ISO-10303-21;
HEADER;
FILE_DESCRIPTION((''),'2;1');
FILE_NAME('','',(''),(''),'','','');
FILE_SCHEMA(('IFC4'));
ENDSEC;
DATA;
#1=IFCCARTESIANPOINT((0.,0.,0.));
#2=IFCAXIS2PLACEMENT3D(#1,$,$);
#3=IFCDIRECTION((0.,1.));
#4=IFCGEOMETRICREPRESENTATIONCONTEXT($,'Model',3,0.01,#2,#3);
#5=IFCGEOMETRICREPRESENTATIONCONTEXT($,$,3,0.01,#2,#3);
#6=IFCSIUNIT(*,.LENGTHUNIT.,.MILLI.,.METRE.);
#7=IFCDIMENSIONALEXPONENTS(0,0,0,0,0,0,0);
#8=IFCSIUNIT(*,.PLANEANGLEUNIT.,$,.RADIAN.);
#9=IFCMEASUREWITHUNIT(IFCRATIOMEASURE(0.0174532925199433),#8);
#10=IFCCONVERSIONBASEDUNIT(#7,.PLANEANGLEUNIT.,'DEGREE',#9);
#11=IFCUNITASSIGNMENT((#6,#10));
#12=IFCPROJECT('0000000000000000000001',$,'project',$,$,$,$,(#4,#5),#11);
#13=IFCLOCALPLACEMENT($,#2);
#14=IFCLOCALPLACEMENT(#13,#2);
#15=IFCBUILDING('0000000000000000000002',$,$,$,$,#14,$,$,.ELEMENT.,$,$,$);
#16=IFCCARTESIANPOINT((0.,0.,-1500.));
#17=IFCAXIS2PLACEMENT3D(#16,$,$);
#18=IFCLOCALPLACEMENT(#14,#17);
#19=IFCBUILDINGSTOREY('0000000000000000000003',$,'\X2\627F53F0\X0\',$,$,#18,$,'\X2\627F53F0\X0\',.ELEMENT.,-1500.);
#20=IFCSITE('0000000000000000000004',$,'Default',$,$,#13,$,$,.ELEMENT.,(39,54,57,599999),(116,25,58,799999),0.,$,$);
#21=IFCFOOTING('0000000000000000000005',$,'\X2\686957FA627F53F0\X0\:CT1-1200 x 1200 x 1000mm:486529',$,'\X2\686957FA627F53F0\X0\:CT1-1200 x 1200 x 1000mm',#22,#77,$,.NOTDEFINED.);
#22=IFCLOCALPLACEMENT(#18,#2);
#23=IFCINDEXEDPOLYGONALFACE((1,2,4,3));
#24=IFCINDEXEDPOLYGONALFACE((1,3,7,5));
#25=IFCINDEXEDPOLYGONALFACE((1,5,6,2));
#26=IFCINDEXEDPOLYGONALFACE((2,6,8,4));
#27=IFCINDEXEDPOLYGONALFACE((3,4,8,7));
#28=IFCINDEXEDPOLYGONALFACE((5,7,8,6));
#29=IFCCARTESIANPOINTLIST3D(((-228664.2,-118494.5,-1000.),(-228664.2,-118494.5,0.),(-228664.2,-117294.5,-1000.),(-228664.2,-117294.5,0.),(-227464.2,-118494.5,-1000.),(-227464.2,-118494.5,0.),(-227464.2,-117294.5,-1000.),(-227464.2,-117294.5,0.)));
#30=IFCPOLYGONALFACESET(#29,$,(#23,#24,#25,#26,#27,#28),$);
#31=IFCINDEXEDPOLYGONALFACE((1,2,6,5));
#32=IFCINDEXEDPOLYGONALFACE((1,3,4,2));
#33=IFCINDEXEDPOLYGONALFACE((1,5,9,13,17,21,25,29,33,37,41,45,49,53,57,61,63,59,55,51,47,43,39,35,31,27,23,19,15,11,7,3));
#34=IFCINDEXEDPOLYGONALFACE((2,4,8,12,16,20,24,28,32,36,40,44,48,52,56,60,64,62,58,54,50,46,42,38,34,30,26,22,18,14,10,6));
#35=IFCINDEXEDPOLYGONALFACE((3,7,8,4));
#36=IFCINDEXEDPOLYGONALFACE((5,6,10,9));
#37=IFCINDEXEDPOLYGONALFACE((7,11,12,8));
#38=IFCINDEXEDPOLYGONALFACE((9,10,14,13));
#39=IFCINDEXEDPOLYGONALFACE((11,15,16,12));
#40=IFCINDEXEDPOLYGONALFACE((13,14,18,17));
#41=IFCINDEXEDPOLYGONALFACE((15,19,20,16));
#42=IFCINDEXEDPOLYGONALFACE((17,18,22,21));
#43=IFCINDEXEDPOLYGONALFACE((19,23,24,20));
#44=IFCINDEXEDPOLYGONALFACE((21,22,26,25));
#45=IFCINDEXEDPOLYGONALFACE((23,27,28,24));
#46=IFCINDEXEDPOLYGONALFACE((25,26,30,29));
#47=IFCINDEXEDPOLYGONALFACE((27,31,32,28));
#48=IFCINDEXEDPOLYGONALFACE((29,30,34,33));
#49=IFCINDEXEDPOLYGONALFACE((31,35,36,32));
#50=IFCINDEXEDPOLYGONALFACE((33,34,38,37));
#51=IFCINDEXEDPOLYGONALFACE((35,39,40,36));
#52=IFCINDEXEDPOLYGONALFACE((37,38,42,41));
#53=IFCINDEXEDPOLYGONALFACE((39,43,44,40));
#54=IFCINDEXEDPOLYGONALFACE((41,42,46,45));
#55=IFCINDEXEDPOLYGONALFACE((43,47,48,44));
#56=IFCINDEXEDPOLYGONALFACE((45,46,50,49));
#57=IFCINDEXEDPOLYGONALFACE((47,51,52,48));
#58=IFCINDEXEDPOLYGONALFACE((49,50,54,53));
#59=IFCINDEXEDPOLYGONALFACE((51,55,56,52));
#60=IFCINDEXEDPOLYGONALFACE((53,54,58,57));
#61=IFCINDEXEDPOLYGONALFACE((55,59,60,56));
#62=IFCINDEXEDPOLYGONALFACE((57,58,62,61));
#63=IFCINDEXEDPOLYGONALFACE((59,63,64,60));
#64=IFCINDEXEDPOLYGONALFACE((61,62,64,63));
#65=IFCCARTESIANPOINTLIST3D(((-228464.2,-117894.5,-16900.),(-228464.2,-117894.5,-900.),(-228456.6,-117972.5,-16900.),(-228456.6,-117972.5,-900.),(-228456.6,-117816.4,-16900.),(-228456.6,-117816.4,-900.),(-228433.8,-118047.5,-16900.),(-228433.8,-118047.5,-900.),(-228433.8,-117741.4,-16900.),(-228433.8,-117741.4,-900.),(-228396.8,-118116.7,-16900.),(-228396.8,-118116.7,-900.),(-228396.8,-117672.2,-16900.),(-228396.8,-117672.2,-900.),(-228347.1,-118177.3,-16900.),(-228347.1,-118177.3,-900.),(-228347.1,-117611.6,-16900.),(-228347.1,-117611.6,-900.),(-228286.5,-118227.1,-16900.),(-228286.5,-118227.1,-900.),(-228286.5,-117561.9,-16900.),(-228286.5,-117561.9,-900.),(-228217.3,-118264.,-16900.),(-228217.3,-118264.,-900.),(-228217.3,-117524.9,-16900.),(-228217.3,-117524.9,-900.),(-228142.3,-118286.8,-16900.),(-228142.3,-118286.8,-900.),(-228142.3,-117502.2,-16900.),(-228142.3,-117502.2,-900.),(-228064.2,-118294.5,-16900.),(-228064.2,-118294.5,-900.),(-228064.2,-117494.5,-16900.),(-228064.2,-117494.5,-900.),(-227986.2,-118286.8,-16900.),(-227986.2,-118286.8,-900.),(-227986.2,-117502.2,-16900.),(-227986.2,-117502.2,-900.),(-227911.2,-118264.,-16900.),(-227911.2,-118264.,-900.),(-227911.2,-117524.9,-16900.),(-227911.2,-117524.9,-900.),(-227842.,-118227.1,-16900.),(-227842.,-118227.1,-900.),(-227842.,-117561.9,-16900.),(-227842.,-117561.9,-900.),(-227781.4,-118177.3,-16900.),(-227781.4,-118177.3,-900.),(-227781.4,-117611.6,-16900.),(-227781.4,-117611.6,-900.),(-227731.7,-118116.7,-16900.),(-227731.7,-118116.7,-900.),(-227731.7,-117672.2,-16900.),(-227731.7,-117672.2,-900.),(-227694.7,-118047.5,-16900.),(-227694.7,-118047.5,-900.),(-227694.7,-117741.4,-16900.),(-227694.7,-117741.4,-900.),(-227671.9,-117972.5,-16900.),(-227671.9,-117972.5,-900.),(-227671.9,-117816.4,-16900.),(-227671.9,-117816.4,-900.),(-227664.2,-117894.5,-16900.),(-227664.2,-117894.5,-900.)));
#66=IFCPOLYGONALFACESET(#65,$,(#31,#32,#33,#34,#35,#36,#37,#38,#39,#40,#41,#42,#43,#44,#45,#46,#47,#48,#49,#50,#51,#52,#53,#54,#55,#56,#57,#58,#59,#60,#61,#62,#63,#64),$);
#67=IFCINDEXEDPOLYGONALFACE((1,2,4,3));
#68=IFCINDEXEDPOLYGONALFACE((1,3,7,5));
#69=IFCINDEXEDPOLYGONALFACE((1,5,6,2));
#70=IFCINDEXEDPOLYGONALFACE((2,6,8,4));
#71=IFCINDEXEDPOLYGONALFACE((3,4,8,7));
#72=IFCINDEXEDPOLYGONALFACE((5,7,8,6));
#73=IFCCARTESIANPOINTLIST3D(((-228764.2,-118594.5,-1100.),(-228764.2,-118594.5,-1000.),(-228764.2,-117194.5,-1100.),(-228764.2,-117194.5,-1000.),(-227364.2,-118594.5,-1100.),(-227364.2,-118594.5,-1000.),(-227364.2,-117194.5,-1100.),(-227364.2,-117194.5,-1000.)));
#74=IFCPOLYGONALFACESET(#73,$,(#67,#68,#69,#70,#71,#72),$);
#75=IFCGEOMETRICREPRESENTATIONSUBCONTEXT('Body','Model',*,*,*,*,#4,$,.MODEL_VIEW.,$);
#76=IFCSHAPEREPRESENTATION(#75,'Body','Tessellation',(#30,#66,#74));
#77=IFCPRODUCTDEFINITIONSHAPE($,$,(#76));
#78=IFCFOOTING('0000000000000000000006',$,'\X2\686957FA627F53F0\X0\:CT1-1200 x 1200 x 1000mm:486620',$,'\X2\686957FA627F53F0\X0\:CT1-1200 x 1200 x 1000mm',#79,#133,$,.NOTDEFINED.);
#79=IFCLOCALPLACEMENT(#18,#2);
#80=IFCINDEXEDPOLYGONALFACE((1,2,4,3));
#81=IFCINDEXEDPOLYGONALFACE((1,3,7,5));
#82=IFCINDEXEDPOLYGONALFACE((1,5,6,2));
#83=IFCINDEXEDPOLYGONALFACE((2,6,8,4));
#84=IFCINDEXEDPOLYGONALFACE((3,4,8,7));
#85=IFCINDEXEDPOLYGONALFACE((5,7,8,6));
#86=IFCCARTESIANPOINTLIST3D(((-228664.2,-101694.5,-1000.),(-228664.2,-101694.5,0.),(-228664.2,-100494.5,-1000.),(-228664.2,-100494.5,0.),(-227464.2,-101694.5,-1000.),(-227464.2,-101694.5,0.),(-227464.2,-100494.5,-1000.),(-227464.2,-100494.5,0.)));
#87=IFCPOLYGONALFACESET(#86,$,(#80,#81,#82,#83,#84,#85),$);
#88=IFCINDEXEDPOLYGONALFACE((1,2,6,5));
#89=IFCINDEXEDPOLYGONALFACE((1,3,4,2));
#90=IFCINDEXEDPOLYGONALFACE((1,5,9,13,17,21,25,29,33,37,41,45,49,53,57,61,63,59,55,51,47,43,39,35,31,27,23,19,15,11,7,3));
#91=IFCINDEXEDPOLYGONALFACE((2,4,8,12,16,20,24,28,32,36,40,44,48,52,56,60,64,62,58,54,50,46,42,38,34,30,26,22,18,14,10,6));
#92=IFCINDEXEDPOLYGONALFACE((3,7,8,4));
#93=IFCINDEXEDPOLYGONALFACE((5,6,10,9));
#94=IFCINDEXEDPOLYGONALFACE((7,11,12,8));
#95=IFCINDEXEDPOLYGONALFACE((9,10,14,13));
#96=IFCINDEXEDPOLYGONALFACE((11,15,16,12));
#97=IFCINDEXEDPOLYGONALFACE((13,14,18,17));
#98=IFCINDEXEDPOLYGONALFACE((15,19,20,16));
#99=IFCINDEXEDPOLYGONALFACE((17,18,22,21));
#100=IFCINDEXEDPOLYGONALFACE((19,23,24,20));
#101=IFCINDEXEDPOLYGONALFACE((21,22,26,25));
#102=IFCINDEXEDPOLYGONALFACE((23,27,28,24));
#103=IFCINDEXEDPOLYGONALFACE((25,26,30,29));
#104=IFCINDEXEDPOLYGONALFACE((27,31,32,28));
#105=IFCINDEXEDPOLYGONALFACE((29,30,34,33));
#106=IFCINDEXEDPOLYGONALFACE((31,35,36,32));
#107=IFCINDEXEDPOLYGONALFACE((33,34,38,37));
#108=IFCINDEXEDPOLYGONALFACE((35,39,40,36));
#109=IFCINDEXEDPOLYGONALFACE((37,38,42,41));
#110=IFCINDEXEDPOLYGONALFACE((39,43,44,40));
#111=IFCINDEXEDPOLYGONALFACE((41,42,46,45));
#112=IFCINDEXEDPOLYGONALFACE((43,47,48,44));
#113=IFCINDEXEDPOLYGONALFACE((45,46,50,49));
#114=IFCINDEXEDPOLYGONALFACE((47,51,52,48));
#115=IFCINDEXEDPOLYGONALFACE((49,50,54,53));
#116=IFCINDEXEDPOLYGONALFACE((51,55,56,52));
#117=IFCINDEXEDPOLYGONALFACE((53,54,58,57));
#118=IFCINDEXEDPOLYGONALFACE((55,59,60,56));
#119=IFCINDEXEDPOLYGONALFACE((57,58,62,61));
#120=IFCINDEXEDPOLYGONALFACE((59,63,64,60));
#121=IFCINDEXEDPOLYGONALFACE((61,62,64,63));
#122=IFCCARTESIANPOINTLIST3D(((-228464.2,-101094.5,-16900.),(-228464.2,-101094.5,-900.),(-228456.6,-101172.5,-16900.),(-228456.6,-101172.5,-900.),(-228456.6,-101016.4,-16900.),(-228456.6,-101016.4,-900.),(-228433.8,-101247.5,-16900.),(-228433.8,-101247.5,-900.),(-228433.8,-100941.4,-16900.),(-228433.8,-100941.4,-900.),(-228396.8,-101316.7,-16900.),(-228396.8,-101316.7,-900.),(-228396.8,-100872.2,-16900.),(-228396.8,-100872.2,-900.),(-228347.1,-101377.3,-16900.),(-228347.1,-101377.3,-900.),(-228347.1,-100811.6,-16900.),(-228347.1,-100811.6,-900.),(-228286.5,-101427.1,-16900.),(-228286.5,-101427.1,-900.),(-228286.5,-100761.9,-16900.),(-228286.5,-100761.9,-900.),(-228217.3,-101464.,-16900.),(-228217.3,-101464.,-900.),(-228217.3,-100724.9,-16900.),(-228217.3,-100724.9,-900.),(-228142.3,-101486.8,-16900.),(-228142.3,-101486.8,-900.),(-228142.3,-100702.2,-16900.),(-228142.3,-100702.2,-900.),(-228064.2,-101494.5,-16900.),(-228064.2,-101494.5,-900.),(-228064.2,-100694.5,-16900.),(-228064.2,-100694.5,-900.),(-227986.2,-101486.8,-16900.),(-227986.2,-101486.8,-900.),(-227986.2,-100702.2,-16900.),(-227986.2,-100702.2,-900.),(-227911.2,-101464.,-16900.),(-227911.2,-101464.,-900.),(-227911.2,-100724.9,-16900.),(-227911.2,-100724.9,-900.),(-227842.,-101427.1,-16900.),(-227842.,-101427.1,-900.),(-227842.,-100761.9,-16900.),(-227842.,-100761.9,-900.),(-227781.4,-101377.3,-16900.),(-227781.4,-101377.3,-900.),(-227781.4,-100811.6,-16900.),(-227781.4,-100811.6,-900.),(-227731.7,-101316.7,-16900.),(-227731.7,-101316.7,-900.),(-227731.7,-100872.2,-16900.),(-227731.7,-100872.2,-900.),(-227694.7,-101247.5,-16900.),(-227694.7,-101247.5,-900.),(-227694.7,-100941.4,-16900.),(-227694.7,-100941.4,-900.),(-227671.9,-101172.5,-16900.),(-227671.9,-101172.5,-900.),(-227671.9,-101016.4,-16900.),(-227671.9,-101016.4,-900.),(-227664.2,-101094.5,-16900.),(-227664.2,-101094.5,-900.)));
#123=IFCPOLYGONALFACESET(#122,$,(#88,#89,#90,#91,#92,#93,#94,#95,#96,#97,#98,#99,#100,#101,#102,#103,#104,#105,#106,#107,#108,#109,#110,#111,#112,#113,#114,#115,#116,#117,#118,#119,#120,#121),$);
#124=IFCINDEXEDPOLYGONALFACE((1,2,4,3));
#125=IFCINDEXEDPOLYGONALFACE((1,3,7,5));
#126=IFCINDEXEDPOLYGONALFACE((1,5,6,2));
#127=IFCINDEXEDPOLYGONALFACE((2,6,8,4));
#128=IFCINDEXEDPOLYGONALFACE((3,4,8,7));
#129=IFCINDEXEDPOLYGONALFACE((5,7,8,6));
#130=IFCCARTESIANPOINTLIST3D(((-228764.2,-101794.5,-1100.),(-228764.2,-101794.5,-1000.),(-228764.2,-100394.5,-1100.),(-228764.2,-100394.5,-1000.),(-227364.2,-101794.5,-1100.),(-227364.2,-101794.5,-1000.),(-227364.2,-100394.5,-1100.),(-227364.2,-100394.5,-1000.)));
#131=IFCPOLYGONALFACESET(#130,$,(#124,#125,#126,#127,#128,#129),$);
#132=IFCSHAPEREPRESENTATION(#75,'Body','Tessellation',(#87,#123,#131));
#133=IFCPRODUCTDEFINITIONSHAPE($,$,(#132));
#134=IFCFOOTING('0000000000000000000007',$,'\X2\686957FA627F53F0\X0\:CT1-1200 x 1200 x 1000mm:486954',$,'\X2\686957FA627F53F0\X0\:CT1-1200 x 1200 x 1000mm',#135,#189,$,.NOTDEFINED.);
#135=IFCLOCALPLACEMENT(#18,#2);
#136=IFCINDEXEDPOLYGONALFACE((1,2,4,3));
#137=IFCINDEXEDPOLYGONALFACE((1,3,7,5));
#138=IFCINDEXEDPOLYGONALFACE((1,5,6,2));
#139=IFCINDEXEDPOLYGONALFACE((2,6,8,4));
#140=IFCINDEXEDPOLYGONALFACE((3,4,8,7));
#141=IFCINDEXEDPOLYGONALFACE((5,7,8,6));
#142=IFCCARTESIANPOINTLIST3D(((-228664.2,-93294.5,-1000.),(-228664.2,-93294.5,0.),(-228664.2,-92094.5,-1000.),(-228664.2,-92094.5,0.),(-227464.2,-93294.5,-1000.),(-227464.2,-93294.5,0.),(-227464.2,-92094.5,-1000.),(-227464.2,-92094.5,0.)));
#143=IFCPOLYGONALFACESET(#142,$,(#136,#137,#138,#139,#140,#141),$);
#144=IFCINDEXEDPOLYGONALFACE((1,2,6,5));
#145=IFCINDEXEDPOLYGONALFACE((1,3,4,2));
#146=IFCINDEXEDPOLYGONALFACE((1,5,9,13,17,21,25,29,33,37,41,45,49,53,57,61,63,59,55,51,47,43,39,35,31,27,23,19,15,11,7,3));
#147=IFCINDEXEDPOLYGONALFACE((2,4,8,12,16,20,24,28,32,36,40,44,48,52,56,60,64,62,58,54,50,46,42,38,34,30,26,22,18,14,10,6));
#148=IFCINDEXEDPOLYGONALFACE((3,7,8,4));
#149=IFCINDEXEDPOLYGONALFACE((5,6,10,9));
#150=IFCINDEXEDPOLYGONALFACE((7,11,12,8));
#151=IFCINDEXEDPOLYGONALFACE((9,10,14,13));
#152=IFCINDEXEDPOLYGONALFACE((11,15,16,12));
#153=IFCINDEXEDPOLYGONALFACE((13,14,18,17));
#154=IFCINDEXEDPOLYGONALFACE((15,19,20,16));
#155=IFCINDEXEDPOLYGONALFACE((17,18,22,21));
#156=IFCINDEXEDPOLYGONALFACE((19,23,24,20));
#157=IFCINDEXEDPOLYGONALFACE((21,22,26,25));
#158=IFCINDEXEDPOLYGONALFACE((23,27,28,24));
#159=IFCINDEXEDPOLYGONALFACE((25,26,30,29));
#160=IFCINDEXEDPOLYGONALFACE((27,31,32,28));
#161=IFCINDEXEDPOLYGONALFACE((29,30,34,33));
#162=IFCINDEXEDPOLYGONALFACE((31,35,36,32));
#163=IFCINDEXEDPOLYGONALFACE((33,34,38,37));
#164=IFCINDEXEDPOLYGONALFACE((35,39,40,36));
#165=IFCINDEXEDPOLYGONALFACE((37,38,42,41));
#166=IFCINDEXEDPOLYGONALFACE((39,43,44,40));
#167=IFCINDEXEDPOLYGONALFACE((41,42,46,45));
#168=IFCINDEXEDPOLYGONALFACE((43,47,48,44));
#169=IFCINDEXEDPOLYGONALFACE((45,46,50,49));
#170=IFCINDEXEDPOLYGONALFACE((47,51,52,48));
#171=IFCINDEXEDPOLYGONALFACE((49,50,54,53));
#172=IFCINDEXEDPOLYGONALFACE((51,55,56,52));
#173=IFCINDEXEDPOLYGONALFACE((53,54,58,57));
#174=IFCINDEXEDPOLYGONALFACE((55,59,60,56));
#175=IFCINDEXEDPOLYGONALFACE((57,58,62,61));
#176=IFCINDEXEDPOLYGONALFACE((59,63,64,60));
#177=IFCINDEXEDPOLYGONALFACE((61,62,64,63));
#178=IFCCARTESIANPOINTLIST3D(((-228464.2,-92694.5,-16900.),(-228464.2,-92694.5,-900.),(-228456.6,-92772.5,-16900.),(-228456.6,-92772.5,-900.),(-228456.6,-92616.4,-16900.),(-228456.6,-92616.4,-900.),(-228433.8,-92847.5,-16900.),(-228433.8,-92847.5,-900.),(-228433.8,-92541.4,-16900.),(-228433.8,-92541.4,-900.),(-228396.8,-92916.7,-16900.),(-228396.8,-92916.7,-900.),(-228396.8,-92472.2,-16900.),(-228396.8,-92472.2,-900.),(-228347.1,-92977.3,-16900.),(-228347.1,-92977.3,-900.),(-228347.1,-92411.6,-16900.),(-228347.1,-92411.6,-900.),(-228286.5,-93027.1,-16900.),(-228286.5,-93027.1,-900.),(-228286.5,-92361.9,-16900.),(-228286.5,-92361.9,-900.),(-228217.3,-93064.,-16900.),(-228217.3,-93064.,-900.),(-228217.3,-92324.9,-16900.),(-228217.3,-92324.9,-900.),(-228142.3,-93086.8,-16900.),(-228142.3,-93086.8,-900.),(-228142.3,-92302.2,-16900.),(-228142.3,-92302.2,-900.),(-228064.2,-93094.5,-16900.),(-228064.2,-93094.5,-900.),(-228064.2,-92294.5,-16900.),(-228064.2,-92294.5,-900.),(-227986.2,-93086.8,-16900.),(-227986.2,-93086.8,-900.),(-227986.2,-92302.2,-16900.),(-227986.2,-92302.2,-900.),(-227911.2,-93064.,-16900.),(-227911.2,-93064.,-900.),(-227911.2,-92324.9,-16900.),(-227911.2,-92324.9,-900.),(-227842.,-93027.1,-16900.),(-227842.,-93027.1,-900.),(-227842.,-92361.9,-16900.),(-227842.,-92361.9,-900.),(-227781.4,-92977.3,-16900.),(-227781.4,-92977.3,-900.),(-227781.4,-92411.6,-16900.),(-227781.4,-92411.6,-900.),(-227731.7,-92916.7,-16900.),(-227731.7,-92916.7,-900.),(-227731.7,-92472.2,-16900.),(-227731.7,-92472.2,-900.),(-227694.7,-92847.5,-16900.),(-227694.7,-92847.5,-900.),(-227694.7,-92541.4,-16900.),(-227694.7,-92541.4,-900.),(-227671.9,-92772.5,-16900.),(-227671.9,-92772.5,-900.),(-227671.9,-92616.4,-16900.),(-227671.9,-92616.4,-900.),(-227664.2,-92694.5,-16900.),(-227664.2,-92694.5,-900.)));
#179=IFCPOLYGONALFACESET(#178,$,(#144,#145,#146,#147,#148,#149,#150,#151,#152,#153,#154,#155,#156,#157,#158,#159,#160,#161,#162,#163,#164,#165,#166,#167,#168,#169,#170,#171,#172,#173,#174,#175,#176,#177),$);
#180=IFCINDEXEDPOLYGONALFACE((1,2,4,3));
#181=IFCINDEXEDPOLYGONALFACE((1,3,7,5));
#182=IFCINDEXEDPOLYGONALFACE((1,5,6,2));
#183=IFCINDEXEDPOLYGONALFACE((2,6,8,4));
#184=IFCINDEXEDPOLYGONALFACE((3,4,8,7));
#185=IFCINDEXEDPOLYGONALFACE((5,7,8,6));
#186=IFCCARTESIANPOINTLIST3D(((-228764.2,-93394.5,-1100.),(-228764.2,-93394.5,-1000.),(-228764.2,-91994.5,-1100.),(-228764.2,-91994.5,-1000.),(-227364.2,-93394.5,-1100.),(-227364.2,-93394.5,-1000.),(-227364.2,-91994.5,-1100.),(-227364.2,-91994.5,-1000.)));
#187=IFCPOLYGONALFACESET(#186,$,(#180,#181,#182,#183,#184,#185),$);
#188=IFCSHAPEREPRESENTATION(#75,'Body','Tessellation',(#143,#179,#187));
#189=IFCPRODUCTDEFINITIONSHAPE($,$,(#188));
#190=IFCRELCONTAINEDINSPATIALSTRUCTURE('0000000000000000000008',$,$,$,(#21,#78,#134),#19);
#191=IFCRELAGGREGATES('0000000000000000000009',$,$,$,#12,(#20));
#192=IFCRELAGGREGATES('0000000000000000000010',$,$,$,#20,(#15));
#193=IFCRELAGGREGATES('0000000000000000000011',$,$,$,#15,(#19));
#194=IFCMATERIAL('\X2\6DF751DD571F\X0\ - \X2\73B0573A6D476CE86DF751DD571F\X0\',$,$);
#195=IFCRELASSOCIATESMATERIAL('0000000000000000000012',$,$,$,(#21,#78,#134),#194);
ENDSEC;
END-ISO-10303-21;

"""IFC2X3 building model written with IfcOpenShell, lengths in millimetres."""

from ifc_helpers import new_model, entity, si_unit, converted_unit, direction, frame, frame_2d, origin, origin_2d_with_axis, place, context, subcontext, project, spatial, rectangle, circle, extrude, material, element, save


model = new_model("IFC2X3")

# Units and contexts
model_context = context("Model", 3, precision=0.01, world=origin(), true_north=direction((0.0, 1.0)))
context_of_model = context(None, 3, precision=0.01, world=origin(), true_north=direction((0.0, 1.0)))
body_context = subcontext(model_context, "Body", "Model", "MODEL_VIEW")
ifc_project = project(units=[si_unit("LENGTHUNIT", "METRE", prefix="MILLI"), converted_unit("PLANEANGLEUNIT", "DEGREE", entity("IfcRatioMeasure", 0.0174532925199433), si_unit("PLANEANGLEUNIT", "RADIAN"), dimensions=[0, 0, 0, 0, 0, 0, 0])], contexts=[model_context, context_of_model])

# Site, building, storey
site_placement = place(None, origin())
site = spatial("IfcSite", under=ifc_project, at=site_placement, Name="Default", CompositionType="ELEMENT", RefLatitude=(39, 54, 57, 599999), RefLongitude=(116, 25, 58, 799999), RefElevation=0.0)
building_placement = place(site_placement, origin())
building = spatial("IfcBuilding", under=site, at=building_placement, CompositionType="ELEMENT")
storey_placement = place(building_placement, frame((0.0, 0.0, -1500.0)))
storey = spatial("IfcBuildingStorey", under=building, at=storey_placement, Name="承台", LongName="承台", CompositionType="ELEMENT", Elevation=-1500.0)

# Footings
ifc_material_1 = material(Name="混凝土 - 现场浇注混凝土")
footing_1_placement = place(storey_placement, frame((-228764.2, -118594.5, -16900.0)))
element("IfcFooting", 1, at=footing_1_placement, inside=storey, material=ifc_material_1, Name="桩基承台:CT1-1200 x 1200 x 1000mm:486529", ObjectType="桩基承台:CT1-1200 x 1200 x 1000mm", PredefinedType="NOTDEFINED", context=body_context, shape_type="SweptSolid", body=[
    extrude(rectangle(XDim=1200.0, YDim=1200.0, at=origin_2d_with_axis()), frame((700.0, 700.0, 15900.0), z_axis=(0.0, 0.0, 1.0), x_axis=(-1.0, 0.0, 0.0)), (0.0, 0.0, 1.0), 1000.0),
    extrude(circle(Radius=400.0, at=origin_2d_with_axis()), frame((700.0, 700.0, 0.0)), (0.0, 0.0, 1.0), 16000.0),
    extrude(rectangle(XDim=1400.0, YDim=1400.0, at=frame_2d((0.0, 0.0), x_axis=(1.0, 0.0))), frame((700.0, 700.0, 15800.0), z_axis=(0.0, 0.0, 1.0), x_axis=(0.0, 1.0, 0.0)), (0.0, 0.0, 1.0), 100.0),
])
for number, where, name in (
    (2, (-228764.2, -101794.5, -16900.0), "桩基承台:CT1-1200 x 1200 x 1000mm:486620"),
    (3, (-228764.2, -93394.5, -16900.0), "桩基承台:CT1-1200 x 1200 x 1000mm:486954"),
):
    element("IfcFooting", number, at=place(storey_placement, frame(where)), inside=storey, material=ifc_material_1, Name=name, ObjectType="桩基承台:CT1-1200 x 1200 x 1000mm", PredefinedType="NOTDEFINED", context=body_context, shape_type="SweptSolid", body=[
        extrude(rectangle(XDim=1200.0, YDim=1200.0, at=origin_2d_with_axis()), frame((700.0, 700.0, 15900.0), z_axis=(0.0, 0.0, 1.0), x_axis=(-1.0, 0.0, 0.0)), (0.0, 0.0, 1.0), 1000.0),
        extrude(circle(Radius=400.0, at=origin_2d_with_axis()), frame((700.0, 700.0, 0.0)), (0.0, 0.0, 1.0), 16000.0),
        extrude(rectangle(XDim=1400.0, YDim=1400.0, at=frame_2d((0.0, 0.0), x_axis=(1.0, 0.0))), frame((700.0, 700.0, 15800.0), z_axis=(0.0, 0.0, 1.0), x_axis=(0.0, 1.0, 0.0)), (0.0, 0.0, 1.0), 100.0),
    ])

save(model, "model.ifc")
